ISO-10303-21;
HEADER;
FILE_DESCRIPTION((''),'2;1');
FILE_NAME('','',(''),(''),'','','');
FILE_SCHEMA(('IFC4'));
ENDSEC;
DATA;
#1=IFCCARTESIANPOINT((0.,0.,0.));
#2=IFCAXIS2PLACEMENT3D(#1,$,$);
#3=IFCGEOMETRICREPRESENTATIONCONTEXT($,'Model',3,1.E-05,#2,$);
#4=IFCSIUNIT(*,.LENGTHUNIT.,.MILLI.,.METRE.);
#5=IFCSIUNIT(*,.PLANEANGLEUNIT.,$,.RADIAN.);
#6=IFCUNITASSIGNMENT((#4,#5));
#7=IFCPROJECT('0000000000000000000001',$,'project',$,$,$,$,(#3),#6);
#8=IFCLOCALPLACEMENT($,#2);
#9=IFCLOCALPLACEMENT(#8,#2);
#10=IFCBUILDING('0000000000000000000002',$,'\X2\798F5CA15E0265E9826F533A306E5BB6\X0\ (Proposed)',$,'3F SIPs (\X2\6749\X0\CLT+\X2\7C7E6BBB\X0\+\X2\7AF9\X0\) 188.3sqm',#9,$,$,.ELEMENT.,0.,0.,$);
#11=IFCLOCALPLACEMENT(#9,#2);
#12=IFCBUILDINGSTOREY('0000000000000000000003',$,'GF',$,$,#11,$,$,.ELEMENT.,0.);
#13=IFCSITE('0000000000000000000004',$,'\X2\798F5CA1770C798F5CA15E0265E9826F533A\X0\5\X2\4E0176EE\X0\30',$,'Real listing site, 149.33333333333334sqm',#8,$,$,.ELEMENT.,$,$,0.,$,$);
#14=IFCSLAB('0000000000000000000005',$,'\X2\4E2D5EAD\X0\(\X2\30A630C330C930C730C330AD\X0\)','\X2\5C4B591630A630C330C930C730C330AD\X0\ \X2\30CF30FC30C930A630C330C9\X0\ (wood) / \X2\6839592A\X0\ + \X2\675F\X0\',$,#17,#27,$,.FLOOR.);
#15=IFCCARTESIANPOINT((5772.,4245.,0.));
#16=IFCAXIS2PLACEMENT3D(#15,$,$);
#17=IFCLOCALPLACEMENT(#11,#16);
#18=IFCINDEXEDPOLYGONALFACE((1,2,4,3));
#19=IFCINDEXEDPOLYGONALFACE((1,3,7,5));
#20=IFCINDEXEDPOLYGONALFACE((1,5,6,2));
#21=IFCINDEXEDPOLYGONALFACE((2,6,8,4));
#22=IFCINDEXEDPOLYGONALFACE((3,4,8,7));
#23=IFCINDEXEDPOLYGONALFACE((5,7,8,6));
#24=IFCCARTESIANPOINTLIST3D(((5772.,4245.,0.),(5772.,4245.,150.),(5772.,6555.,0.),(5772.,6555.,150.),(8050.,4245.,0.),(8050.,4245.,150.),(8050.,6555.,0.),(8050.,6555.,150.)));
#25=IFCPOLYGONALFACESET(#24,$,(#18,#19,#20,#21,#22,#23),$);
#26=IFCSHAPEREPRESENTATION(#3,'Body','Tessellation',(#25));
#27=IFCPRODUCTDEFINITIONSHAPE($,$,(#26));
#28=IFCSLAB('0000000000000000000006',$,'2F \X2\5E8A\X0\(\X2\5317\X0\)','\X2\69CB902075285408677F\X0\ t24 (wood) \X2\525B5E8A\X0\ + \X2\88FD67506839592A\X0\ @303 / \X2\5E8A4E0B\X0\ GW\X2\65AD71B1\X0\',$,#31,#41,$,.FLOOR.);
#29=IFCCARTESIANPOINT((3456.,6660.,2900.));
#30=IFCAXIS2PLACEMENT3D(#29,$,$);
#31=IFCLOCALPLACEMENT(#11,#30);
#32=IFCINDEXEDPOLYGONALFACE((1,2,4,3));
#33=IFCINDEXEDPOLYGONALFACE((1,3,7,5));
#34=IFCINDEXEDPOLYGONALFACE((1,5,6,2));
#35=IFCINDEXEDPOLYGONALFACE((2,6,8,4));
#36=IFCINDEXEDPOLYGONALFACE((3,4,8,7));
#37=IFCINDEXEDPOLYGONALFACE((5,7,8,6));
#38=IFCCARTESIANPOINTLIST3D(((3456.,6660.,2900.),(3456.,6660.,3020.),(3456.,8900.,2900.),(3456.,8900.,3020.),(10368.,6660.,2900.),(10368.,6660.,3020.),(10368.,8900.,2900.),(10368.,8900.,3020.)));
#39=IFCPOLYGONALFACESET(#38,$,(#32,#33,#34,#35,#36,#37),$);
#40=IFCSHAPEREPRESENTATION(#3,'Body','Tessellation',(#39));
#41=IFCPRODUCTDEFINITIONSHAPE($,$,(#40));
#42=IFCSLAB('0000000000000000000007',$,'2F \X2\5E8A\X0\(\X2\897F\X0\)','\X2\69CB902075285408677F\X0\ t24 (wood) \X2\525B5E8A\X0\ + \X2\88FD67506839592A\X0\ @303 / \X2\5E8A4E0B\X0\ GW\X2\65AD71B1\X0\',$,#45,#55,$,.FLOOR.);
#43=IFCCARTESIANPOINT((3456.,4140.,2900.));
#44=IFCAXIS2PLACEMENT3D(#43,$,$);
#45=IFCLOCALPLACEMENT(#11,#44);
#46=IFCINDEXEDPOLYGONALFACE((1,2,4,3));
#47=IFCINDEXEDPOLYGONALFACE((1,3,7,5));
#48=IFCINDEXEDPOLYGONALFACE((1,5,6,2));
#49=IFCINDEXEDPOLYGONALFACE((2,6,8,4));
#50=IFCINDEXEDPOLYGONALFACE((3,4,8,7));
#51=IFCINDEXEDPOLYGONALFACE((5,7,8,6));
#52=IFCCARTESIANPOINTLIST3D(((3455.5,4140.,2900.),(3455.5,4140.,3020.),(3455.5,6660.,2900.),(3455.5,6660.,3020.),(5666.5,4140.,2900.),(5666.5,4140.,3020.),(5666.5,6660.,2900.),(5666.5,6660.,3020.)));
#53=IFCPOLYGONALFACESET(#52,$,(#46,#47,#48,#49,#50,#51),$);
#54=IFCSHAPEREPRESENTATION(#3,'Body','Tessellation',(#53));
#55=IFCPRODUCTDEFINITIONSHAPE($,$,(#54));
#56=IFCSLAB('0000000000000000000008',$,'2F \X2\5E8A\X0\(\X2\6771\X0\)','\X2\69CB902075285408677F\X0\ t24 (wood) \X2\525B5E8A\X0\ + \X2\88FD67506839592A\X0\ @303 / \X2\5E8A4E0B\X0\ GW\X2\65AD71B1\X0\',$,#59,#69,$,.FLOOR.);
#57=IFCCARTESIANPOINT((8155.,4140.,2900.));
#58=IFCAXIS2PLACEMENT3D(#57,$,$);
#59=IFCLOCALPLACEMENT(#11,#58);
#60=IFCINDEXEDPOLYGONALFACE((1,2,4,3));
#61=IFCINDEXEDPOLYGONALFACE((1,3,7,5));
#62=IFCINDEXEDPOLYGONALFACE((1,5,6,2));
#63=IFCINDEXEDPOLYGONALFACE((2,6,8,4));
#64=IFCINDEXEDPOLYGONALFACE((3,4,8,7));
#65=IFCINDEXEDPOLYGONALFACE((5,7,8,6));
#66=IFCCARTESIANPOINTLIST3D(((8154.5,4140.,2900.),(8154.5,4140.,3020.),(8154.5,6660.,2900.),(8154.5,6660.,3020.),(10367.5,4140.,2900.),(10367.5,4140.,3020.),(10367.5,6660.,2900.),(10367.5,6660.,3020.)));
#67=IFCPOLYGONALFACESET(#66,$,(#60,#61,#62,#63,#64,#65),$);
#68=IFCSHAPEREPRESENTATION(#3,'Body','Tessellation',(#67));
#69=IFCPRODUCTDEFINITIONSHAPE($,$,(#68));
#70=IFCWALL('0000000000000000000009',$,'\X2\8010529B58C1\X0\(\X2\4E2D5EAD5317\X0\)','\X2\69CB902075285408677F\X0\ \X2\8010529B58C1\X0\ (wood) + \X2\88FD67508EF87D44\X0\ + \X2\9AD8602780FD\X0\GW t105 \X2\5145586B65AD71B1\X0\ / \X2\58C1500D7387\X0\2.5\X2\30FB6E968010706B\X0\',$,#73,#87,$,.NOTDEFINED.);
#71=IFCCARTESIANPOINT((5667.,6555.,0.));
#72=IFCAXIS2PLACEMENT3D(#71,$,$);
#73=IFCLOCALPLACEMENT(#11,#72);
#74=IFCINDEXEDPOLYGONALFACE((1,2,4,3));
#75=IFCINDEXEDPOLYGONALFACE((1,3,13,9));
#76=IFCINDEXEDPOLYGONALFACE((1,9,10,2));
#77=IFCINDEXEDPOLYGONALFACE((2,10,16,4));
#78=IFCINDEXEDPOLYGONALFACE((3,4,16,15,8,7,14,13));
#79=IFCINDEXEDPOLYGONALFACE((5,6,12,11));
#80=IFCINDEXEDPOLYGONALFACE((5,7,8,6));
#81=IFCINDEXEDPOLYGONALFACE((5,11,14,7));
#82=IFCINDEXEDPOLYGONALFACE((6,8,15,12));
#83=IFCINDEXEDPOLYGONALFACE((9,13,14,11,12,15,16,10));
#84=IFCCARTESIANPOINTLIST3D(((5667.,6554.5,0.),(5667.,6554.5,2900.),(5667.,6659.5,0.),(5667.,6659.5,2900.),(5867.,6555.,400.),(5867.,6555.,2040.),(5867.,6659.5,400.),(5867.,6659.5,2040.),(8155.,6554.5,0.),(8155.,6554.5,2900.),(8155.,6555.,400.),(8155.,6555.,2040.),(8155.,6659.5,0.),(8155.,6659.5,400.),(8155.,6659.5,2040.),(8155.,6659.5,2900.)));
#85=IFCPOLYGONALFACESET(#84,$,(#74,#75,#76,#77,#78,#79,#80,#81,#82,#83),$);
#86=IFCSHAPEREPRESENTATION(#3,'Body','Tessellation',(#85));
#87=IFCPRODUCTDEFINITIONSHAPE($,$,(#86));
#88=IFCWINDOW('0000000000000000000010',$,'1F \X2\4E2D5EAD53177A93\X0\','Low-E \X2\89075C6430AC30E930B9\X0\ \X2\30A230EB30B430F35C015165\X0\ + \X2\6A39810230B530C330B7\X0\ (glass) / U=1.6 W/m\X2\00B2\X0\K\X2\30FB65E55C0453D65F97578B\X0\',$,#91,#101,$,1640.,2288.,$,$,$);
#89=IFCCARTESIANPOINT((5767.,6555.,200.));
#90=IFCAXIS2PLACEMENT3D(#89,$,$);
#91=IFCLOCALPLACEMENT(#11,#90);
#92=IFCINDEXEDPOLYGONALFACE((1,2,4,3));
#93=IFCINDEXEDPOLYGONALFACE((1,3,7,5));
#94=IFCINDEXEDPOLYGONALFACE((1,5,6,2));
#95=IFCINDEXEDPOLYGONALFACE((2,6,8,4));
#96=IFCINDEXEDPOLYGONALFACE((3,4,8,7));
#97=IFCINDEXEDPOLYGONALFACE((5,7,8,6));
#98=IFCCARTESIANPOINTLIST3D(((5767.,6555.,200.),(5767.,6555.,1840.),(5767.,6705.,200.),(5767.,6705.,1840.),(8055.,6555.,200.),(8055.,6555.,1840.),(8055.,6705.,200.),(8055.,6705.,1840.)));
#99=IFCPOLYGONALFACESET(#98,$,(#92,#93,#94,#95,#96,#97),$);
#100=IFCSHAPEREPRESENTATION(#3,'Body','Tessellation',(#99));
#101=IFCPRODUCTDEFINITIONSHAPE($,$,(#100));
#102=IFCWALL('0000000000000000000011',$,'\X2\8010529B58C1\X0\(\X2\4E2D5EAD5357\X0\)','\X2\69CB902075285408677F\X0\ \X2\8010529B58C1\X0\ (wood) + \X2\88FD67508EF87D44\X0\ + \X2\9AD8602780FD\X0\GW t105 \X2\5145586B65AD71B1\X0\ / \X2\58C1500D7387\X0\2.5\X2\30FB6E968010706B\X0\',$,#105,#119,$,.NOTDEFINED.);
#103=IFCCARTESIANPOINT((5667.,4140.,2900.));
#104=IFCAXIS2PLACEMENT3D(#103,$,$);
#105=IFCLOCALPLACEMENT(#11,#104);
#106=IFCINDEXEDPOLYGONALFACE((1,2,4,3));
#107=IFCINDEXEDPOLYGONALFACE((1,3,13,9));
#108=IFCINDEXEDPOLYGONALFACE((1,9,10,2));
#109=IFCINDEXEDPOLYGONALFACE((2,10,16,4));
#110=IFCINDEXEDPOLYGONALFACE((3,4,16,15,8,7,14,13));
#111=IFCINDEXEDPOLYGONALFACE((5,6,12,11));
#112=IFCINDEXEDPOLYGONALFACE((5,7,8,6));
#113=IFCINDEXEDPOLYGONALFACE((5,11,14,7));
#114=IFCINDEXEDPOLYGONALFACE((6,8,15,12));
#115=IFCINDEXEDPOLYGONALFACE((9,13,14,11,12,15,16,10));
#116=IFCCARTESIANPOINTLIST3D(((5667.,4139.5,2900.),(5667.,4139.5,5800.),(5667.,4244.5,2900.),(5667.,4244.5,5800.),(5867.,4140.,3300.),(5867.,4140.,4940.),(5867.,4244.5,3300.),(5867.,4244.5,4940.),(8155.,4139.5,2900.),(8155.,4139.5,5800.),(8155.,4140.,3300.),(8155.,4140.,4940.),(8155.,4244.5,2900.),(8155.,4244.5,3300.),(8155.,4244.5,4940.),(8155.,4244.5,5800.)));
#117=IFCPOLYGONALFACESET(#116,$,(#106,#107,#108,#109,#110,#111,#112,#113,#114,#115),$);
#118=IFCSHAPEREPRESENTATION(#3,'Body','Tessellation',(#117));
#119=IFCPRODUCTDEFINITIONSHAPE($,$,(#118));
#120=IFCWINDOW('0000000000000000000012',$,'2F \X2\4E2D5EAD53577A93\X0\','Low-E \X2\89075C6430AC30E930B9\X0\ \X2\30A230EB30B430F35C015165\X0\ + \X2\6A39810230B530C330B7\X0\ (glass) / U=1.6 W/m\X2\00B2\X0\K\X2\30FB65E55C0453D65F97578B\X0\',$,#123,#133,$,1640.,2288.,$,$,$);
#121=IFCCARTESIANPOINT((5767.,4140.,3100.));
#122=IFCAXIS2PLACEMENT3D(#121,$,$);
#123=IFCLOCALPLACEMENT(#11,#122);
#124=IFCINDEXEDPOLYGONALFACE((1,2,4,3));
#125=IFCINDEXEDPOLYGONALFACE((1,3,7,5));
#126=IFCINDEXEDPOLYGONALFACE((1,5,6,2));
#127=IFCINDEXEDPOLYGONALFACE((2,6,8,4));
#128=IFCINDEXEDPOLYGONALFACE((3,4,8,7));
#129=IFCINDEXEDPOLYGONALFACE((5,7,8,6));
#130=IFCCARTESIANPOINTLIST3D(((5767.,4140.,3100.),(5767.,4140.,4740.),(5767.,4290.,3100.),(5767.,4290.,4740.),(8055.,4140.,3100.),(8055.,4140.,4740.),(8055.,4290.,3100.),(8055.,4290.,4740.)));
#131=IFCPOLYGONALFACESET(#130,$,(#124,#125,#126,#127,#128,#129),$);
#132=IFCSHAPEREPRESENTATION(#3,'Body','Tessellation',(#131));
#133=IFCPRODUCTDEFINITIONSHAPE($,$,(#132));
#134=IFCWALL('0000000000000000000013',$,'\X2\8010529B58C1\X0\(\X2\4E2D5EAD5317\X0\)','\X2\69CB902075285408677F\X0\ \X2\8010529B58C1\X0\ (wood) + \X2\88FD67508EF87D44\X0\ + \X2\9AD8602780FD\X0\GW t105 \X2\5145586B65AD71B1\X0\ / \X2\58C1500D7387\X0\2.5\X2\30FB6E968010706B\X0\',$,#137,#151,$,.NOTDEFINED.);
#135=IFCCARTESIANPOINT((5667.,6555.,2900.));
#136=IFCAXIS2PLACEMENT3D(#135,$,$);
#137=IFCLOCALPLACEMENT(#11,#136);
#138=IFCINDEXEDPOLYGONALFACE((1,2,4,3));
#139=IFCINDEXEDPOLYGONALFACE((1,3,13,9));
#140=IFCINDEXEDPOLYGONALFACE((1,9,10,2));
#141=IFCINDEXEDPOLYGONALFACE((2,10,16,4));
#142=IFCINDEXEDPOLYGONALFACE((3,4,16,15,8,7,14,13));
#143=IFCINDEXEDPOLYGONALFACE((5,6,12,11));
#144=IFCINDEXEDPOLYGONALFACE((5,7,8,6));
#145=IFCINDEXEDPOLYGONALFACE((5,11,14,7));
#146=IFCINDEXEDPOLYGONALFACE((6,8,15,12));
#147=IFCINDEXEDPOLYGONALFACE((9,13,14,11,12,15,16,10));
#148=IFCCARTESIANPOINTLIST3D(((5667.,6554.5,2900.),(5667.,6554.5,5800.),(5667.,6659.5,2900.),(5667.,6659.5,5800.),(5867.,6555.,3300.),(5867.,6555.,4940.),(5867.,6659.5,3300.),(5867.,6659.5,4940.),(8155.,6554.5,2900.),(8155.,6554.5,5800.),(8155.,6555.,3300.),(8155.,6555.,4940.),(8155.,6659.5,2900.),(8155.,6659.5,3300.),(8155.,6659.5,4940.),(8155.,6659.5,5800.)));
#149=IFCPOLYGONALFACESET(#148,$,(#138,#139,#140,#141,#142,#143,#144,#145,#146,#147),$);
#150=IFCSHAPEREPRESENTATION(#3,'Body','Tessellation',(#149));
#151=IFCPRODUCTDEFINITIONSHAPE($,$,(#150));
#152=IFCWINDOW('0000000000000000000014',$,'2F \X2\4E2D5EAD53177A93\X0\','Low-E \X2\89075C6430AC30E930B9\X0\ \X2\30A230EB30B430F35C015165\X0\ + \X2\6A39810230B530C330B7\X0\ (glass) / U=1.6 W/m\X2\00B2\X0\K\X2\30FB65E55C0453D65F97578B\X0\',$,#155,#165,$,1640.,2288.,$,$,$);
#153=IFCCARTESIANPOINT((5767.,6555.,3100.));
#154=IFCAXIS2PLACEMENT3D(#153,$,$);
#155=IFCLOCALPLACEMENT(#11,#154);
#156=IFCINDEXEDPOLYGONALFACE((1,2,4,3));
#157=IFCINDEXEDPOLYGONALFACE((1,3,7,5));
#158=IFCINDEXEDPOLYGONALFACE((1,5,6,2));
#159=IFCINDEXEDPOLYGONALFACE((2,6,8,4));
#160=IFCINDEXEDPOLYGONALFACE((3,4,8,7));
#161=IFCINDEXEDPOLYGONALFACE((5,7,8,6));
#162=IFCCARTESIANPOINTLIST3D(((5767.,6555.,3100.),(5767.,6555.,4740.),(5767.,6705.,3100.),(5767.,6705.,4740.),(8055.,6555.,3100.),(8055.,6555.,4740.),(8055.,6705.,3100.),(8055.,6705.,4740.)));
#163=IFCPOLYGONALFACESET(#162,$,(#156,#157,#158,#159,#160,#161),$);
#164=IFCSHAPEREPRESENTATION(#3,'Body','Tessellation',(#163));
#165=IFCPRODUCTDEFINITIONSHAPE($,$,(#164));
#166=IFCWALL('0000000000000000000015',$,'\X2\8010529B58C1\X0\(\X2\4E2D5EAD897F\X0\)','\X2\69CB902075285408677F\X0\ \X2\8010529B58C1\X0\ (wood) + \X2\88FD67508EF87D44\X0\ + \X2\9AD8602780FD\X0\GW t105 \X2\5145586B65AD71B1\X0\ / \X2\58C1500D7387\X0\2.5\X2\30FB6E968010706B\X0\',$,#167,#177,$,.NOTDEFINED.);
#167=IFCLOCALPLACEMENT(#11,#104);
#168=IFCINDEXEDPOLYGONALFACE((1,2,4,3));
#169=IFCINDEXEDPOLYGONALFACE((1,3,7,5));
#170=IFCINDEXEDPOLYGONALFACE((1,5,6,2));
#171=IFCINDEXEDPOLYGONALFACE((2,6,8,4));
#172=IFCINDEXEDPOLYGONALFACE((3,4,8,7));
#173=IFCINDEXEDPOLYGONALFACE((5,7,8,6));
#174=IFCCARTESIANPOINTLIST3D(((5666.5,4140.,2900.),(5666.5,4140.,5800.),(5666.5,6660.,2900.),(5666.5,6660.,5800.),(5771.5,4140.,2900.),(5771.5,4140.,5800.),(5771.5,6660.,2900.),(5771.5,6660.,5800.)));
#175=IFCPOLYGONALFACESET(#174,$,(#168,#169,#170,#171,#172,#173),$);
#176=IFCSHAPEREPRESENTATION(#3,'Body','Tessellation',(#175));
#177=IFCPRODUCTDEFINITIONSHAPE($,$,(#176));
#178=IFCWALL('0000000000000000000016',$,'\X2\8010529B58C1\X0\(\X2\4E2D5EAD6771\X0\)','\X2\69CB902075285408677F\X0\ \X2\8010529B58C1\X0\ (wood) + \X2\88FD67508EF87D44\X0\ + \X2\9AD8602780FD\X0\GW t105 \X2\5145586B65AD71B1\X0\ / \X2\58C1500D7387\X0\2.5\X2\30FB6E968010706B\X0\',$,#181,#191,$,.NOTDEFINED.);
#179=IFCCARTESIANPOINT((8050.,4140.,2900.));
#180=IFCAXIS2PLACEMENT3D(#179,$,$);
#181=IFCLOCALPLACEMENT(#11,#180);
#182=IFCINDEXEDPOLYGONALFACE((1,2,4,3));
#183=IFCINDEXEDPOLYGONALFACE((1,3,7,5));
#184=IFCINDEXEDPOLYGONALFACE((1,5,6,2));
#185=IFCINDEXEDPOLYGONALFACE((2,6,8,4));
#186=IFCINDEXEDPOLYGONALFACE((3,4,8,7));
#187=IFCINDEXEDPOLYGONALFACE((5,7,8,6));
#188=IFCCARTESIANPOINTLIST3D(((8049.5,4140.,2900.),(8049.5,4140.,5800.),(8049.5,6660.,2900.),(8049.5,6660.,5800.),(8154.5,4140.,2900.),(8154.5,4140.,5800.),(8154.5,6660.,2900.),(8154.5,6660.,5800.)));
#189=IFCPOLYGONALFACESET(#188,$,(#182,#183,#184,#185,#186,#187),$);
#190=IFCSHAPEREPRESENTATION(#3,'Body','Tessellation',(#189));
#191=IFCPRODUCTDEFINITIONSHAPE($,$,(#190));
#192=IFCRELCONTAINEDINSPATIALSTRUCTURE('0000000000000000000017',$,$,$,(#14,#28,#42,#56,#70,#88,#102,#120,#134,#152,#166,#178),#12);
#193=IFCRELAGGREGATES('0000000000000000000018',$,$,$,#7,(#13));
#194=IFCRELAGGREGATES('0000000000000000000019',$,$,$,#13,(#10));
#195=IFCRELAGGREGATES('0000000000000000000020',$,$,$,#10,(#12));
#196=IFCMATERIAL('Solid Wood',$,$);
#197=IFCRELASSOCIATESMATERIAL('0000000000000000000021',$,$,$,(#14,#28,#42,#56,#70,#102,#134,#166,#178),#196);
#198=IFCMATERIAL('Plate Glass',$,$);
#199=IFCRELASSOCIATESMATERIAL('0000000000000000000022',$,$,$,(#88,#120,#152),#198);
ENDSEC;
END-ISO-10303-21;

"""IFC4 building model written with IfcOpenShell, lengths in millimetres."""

from ifc_helpers import new_model, si_unit, frame, frame_2d, origin, place, context, project, spatial, rectangle, extrude, material, element, fill, save


model = new_model("IFC4")

# Units and contexts
model_context = context("Model", 3, precision=1e-05, world=origin())
ifc_project = project(units=[si_unit("LENGTHUNIT", "METRE", prefix="MILLI"), si_unit("PLANEANGLEUNIT", "RADIAN")], contexts=[model_context])

# Site, building, storey
site_placement = place(None, origin())
site = spatial("IfcSite", under=ifc_project, at=site_placement, Name="福岡県福岡市早良区5丁目30", ObjectType="Real listing site, 149.33333333333334sqm", CompositionType="ELEMENT", RefElevation=0.0)
building_placement = place(site_placement, origin())
building = spatial("IfcBuilding", under=site, at=building_placement, Name="福岡市早良区の家 (Proposed)", ObjectType="3F SIPs (杉CLT+籾殻+竹) 188.3sqm", CompositionType="ELEMENT", ElevationOfRefHeight=0.0, ElevationOfTerrain=0.0)
storey_placement = place(building_placement, origin())
storey = spatial("IfcBuildingStorey", under=building, at=storey_placement, Name="GF", CompositionType="ELEMENT", Elevation=0.0)

# Slabs
ifc_material_1 = material(Name="Solid Wood")
slab_1_placement = place(storey_placement, frame((5772.0, 4245.0, 0.0)))
element("IfcSlab", 1, at=slab_1_placement, inside=storey, material=ifc_material_1, Name="中庭(ウッドデッキ)", Description="屋外ウッドデッキ ハードウッド (wood) / 根太 + 束", PredefinedType="FLOOR", context=model_context, shape_type="SweptSolid", body=[
    extrude(rectangle(XDim=2278.0, YDim=2310.0, at=frame_2d((1139.0, 1155.0))), frame((5772.0, 4245.0, 0.0)), (0.0, 0.0, 1.0), 150.0),
])
slab_2_placement = place(storey_placement, frame((3456.0, 6660.0, 2900.0)))
element("IfcSlab", 2, at=slab_2_placement, inside=storey, material=ifc_material_1, Name="2F 床(北)", Description="構造用合板 t24 (wood) 剛床 + 製材根太 @303 / 床下 GW断熱", PredefinedType="FLOOR", context=model_context, shape_type="SweptSolid", body=[
    extrude(rectangle(XDim=6912.0, YDim=2240.0, at=frame_2d((3456.0, 1120.0))), frame((3456.0, 6660.0, 2900.0)), (0.0, 0.0, 1.0), 120.0),
])
slab_3_placement = place(storey_placement, frame((3456.0, 4140.0, 2900.0)))
element("IfcSlab", 3, at=slab_3_placement, inside=storey, material=ifc_material_1, Name="2F 床(西)", Description="構造用合板 t24 (wood) 剛床 + 製材根太 @303 / 床下 GW断熱", PredefinedType="FLOOR", context=model_context, shape_type="SweptSolid", body=[
    extrude(rectangle(XDim=2211.0, YDim=2520.0, at=frame_2d((1105.0, 1260.0))), frame((3456.0, 4140.0, 2900.0)), (0.0, 0.0, 1.0), 120.0),
])
slab_4_placement = place(storey_placement, frame((8155.0, 4140.0, 2900.0)))
element("IfcSlab", 4, at=slab_4_placement, inside=storey, material=ifc_material_1, Name="2F 床(東)", Description="構造用合板 t24 (wood) 剛床 + 製材根太 @303 / 床下 GW断熱", PredefinedType="FLOOR", context=model_context, shape_type="SweptSolid", body=[
    extrude(rectangle(XDim=2213.0, YDim=2520.0, at=frame_2d((1106.0, 1260.0))), frame((8155.0, 4140.0, 2900.0)), (0.0, 0.0, 1.0), 120.0),
])

# Wall, opening, window
wall_1_placement = place(storey_placement, frame((5667.0, 6555.0, 0.0)))
wall_1 = element("IfcWall", 5, at=wall_1_placement, inside=storey, material=ifc_material_1, Name="耐力壁(中庭北)", Description="構造用合板 耐力壁 (wood) + 製材軸組 + 高性能GW t105 充填断熱 / 壁倍率2.5・準耐火", PredefinedType="NOTDEFINED", context=model_context, shape_type="SweptSolid", body=[
    extrude(rectangle(XDim=2488.0, YDim=105.0, at=frame_2d((1244.0, 52.0))), frame((5667.0, 6555.0, 0.0)), (0.0, 0.0, 1.0), 2900.0),
])
opening_1_placement = place(storey_placement, frame((5767.0, 6555.0, 200.0)))
opening_1 = element("IfcOpeningElement", 6, at=opening_1_placement, cuts=wall_1, PredefinedType="NOTDEFINED", context=model_context, shape_type="SweptSolid", body=[
    extrude(rectangle(XDim=2288.0, YDim=150.0, at=frame_2d((1144.0, 75.0))), frame((5767.0, 6555.0, 200.0)), (0.0, 0.0, 1.0), 1640.0),
])
ifc_material_2 = material(Name="Plate Glass")
window_1_placement = place(storey_placement, frame((5767.0, 6555.0, 200.0)))
window_1 = element("IfcWindow", 7, at=window_1_placement, inside=storey, material=ifc_material_2, Name="1F 中庭北窓", Description="Low-E 複層ガラス アルゴン封入 + 樹脂サッシ (glass) / U=1.6 W/m²K・日射取得型", OverallHeight=1640.0, OverallWidth=2288.0, context=model_context, shape_type="SweptSolid", body=[
    extrude(rectangle(XDim=2288.0, YDim=150.0, at=frame_2d((1144.0, 75.0))), frame((5767.0, 6555.0, 200.0)), (0.0, 0.0, 1.0), 1640.0),
])
fill(opening_1, window_1)

# Walls, openings, windows
wall_2_placement = place(storey_placement, frame((5667.0, 4140.0, 2900.0)))
wall_2 = element("IfcWall", 8, at=wall_2_placement, inside=storey, material=ifc_material_1, Name="耐力壁(中庭南)", Description="構造用合板 耐力壁 (wood) + 製材軸組 + 高性能GW t105 充填断熱 / 壁倍率2.5・準耐火", PredefinedType="NOTDEFINED", context=model_context, shape_type="SweptSolid", body=[
    extrude(rectangle(XDim=2488.0, YDim=105.0, at=frame_2d((1244.0, 52.0))), frame((5667.0, 4140.0, 2900.0)), (0.0, 0.0, 1.0), 2900.0),
])
opening_2_placement = place(storey_placement, frame((5767.0, 4140.0, 3100.0)))
opening_2 = element("IfcOpeningElement", 9, at=opening_2_placement, cuts=wall_2, PredefinedType="NOTDEFINED", context=model_context, shape_type="SweptSolid", body=[
    extrude(rectangle(XDim=2288.0, YDim=150.0, at=frame_2d((1144.0, 75.0))), frame((5767.0, 4140.0, 3100.0)), (0.0, 0.0, 1.0), 1640.0),
])
window_2_placement = place(storey_placement, frame((5767.0, 4140.0, 3100.0)))
window_2 = element("IfcWindow", 10, at=window_2_placement, inside=storey, material=ifc_material_2, Name="2F 中庭南窓", Description="Low-E 複層ガラス アルゴン封入 + 樹脂サッシ (glass) / U=1.6 W/m²K・日射取得型", OverallHeight=1640.0, OverallWidth=2288.0, context=model_context, shape_type="SweptSolid", body=[
    extrude(rectangle(XDim=2288.0, YDim=150.0, at=frame_2d((1144.0, 75.0))), frame((5767.0, 4140.0, 3100.0)), (0.0, 0.0, 1.0), 1640.0),
])
fill(opening_2, window_2)
wall_3_placement = place(storey_placement, frame((5667.0, 6555.0, 2900.0)))
wall_3 = element("IfcWall", 11, at=wall_3_placement, inside=storey, material=ifc_material_1, Name="耐力壁(中庭北)", Description="構造用合板 耐力壁 (wood) + 製材軸組 + 高性能GW t105 充填断熱 / 壁倍率2.5・準耐火", PredefinedType="NOTDEFINED", context=model_context, shape_type="SweptSolid", body=[
    extrude(rectangle(XDim=2488.0, YDim=105.0, at=frame_2d((1244.0, 52.0))), frame((5667.0, 6555.0, 2900.0)), (0.0, 0.0, 1.0), 2900.0),
])
opening_3_placement = place(storey_placement, frame((5767.0, 6555.0, 3100.0)))
opening_3 = element("IfcOpeningElement", 12, at=opening_3_placement, cuts=wall_3, PredefinedType="NOTDEFINED", context=model_context, shape_type="SweptSolid", body=[
    extrude(rectangle(XDim=2288.0, YDim=150.0, at=frame_2d((1144.0, 75.0))), frame((5767.0, 6555.0, 3100.0)), (0.0, 0.0, 1.0), 1640.0),
])
window_3_placement = place(storey_placement, frame((5767.0, 6555.0, 3100.0)))
window_3 = element("IfcWindow", 13, at=window_3_placement, inside=storey, material=ifc_material_2, Name="2F 中庭北窓", Description="Low-E 複層ガラス アルゴン封入 + 樹脂サッシ (glass) / U=1.6 W/m²K・日射取得型", OverallHeight=1640.0, OverallWidth=2288.0, context=model_context, shape_type="SweptSolid", body=[
    extrude(rectangle(XDim=2288.0, YDim=150.0, at=frame_2d((1144.0, 75.0))), frame((5767.0, 6555.0, 3100.0)), (0.0, 0.0, 1.0), 1640.0),
])
fill(opening_3, window_3)

# Walls
wall_4_placement = place(storey_placement, frame((5667.0, 4140.0, 2900.0)))
element("IfcWall", 14, at=wall_4_placement, inside=storey, material=ifc_material_1, Name="耐力壁(中庭西)", Description="構造用合板 耐力壁 (wood) + 製材軸組 + 高性能GW t105 充填断熱 / 壁倍率2.5・準耐火", PredefinedType="NOTDEFINED", context=model_context, shape_type="SweptSolid", body=[
    extrude(rectangle(XDim=105.0, YDim=2520.0, at=frame_2d((52.0, 1260.0))), frame((5667.0, 4140.0, 2900.0)), (0.0, 0.0, 1.0), 2900.0),
])
wall_5_placement = place(storey_placement, frame((8050.0, 4140.0, 2900.0)))
element("IfcWall", 15, at=wall_5_placement, inside=storey, material=ifc_material_1, Name="耐力壁(中庭東)", Description="構造用合板 耐力壁 (wood) + 製材軸組 + 高性能GW t105 充填断熱 / 壁倍率2.5・準耐火", PredefinedType="NOTDEFINED", context=model_context, shape_type="SweptSolid", body=[
    extrude(rectangle(XDim=105.0, YDim=2520.0, at=frame_2d((52.0, 1260.0))), frame((8050.0, 4140.0, 2900.0)), (0.0, 0.0, 1.0), 2900.0),
])

save(model, "model.ifc")
